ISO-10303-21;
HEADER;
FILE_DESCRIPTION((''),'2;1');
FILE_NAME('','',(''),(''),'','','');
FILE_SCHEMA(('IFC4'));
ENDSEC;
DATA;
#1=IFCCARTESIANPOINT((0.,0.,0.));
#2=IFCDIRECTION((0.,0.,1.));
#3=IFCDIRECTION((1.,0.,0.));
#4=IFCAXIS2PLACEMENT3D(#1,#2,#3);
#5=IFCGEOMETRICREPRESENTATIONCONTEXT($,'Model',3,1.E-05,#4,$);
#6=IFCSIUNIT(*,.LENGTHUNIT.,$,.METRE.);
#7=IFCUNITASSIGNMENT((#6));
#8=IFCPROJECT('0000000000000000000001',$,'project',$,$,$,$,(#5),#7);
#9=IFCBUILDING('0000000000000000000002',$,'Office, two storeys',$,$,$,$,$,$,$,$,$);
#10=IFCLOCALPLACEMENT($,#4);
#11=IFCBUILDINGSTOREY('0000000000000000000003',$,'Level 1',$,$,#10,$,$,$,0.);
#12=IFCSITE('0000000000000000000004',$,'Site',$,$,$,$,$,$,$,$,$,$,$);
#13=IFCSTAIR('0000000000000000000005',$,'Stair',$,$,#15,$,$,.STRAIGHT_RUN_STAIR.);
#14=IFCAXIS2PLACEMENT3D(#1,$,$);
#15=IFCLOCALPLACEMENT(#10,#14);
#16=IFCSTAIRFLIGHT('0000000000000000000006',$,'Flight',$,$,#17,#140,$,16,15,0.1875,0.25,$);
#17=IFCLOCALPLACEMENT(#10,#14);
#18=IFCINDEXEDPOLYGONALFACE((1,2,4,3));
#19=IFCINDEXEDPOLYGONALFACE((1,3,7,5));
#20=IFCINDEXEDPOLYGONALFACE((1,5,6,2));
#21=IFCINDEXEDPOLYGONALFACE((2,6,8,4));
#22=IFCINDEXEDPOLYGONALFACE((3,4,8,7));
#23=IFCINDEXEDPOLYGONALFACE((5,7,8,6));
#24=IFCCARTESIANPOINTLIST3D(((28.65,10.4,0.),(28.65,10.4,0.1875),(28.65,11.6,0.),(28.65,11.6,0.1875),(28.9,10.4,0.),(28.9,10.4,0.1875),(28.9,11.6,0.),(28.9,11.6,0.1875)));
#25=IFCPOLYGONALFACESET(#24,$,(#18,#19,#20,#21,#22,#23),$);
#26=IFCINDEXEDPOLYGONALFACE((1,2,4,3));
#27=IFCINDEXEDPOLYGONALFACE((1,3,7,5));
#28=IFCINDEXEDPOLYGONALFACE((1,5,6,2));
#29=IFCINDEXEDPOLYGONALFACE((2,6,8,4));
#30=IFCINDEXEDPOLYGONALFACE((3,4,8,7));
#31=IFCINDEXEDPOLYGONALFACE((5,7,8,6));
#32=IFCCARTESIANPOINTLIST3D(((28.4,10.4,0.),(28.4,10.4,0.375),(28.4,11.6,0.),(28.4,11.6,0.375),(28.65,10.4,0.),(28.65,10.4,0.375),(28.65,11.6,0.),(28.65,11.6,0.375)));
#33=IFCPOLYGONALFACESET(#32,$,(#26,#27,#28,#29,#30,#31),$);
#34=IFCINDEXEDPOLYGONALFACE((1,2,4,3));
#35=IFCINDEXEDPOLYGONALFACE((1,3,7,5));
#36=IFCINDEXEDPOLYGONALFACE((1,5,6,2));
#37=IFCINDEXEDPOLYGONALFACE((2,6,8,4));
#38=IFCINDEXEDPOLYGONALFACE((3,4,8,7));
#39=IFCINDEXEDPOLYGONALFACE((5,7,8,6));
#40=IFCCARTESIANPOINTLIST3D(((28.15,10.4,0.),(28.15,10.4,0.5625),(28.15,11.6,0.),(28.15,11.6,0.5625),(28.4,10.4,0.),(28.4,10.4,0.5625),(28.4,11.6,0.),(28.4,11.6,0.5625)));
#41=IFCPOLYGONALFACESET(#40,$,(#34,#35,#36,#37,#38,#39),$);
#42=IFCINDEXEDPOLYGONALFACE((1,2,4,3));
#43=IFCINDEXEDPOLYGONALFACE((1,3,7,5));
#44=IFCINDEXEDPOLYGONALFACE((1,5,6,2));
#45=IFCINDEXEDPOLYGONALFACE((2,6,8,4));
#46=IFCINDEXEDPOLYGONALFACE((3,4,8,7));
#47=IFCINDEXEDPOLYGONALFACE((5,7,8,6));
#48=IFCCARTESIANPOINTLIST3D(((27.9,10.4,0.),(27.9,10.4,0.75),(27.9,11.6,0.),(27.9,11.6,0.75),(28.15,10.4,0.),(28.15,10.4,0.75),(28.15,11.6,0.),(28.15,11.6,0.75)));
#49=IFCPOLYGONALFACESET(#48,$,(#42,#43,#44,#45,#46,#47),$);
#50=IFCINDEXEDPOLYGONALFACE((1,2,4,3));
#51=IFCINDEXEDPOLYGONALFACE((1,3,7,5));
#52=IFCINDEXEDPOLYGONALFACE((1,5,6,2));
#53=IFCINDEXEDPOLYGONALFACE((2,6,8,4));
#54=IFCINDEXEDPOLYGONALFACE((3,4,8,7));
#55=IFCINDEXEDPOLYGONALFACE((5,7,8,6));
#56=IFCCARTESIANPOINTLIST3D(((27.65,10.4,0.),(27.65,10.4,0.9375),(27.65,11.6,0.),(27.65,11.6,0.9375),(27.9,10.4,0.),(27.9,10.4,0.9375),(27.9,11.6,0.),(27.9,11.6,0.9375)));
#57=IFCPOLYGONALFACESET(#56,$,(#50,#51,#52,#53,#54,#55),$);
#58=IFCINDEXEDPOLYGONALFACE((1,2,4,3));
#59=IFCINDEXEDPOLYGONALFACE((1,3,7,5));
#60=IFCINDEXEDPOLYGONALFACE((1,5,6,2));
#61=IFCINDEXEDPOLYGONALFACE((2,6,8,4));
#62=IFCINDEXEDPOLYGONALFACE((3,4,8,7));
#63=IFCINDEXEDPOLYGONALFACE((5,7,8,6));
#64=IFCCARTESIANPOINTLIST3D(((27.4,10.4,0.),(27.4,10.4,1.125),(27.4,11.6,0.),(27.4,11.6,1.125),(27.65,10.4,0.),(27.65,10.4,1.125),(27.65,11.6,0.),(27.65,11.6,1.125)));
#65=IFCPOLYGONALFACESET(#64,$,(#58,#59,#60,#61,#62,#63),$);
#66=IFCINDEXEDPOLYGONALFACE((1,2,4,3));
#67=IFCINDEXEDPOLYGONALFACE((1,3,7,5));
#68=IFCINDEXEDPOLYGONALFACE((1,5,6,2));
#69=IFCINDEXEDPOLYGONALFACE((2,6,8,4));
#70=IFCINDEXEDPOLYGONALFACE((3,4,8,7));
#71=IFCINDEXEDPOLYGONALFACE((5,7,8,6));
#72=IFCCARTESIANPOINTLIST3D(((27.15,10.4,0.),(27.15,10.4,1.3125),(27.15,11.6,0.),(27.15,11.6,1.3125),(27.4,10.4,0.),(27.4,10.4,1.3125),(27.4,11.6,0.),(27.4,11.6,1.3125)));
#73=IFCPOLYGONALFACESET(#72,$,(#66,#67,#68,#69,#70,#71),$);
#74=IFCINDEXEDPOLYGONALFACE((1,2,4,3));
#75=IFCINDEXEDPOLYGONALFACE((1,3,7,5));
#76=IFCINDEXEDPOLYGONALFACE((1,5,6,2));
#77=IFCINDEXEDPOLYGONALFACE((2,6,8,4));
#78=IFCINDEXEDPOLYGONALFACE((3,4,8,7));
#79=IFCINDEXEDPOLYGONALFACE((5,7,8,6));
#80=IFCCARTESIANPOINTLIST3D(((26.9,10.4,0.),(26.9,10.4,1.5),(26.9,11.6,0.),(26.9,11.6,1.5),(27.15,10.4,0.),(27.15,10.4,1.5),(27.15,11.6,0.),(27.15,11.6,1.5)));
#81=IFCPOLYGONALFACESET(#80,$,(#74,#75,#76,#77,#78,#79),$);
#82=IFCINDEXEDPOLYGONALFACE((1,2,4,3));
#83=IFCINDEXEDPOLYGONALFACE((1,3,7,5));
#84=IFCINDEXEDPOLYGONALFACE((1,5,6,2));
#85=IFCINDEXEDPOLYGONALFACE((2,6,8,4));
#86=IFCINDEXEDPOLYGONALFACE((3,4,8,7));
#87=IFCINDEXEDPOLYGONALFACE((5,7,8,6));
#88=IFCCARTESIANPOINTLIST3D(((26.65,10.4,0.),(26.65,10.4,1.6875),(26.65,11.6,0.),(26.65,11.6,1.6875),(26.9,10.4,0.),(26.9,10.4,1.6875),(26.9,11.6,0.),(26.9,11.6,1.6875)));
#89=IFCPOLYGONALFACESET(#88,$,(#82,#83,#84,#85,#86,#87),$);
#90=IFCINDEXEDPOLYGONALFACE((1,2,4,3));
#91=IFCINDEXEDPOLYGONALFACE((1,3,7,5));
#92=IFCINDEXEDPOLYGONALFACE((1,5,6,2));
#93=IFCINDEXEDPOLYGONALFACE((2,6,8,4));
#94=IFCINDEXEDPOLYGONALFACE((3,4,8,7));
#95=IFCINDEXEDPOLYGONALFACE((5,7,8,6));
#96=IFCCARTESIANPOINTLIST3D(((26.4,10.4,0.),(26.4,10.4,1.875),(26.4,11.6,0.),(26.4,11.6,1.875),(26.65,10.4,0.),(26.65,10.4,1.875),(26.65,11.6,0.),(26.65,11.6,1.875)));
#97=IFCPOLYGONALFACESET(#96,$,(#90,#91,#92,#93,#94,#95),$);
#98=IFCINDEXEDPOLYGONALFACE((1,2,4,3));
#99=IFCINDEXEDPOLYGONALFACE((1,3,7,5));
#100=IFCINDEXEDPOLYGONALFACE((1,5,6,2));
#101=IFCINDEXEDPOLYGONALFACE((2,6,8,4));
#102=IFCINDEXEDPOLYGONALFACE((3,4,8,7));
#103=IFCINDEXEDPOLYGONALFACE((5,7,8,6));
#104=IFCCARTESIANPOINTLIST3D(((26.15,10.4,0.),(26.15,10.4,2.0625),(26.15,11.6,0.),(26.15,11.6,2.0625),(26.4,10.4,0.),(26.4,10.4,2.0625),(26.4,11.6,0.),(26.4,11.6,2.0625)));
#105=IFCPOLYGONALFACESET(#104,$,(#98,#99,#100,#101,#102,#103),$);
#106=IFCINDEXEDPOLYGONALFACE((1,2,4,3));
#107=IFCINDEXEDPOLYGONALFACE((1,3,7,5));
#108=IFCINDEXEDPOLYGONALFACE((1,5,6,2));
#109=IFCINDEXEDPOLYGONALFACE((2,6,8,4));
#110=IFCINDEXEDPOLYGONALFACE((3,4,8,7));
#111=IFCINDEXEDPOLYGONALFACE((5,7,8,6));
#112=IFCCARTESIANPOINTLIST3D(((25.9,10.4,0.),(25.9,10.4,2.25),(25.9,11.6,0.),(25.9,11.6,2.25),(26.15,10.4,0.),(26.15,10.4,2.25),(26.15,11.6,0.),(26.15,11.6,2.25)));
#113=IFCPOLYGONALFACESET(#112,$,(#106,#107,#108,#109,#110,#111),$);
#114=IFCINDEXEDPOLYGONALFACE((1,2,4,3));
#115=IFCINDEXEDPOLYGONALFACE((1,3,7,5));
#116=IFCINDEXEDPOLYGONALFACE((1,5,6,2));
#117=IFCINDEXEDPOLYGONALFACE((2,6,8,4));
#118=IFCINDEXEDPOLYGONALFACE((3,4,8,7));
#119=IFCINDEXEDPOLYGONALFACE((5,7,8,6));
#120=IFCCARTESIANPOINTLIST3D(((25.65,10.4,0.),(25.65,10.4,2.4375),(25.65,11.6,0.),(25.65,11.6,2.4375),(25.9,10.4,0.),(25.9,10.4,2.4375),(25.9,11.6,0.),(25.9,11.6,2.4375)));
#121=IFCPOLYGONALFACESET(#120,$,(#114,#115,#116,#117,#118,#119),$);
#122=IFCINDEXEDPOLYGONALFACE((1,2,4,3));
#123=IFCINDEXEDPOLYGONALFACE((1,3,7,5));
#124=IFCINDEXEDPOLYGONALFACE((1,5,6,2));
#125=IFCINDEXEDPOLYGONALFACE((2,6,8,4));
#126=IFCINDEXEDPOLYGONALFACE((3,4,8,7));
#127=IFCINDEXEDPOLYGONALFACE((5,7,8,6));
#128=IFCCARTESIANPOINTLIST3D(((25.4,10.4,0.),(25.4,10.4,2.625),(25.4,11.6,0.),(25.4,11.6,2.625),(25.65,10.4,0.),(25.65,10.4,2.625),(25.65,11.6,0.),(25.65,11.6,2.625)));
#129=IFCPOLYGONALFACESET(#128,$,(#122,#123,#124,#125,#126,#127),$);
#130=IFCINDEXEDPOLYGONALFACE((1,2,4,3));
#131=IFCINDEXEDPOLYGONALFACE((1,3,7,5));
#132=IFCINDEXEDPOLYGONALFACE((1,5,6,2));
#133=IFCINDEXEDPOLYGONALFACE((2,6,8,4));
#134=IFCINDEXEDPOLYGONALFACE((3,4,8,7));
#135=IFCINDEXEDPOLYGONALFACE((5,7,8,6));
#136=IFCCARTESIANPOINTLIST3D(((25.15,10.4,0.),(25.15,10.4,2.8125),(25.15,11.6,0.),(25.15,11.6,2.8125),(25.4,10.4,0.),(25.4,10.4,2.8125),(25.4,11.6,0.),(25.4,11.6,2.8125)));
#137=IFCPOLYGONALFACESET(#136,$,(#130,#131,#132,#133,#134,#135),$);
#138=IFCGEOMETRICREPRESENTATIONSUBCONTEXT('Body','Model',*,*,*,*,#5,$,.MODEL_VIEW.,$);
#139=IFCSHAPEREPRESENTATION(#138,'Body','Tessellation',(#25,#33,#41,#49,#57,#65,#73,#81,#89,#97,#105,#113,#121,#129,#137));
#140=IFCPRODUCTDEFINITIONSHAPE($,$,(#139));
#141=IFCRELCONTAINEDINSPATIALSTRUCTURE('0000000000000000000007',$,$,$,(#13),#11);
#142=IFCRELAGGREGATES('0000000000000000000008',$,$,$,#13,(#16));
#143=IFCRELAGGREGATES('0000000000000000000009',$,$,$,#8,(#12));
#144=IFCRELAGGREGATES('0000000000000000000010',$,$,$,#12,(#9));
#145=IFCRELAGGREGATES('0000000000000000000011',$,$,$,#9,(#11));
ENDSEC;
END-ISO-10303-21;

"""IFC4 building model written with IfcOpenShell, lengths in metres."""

from ifc_helpers import new_model, si_unit, frame, origin_with_axes, place, context, subcontext, project, spatial, line, indexed_curve, outline, extrude, element, aggregate, save


model = new_model("IFC4")

# Units and contexts
model_context = context("Model", 3, precision=1e-05, world=origin_with_axes())
body_context = subcontext(model_context, "Body", "Model", "MODEL_VIEW")
ifc_project = project(units=[si_unit("LENGTHUNIT", "METRE")], contexts=[model_context])

# Site, building, storey
site = spatial("IfcSite", under=ifc_project, Name="Site")
building = spatial("IfcBuilding", under=site, Name="Office, two storeys")
storey_placement = place(None, origin_with_axes())
storey = spatial("IfcBuildingStorey", under=building, at=storey_placement, Name="Level 1", Elevation=0.0)

# Stair, stair flight
stair_placement = place(storey_placement, frame((28.9, 11.0, 0.0), z_axis=(0.0, 0.0, 1.0), x_axis=(-1.0, 0.0, 0.0)))
stair = element("IfcStair", 1, at=stair_placement, inside=storey, Name="Stair", PredefinedType="STRAIGHT_RUN_STAIR")
stair_flight_placement = place(stair_placement, origin_with_axes())
stair_flight = element("IfcStairFlight", 2, at=stair_flight_placement, Name="Flight", NumberOfRisers=16, NumberOfTreads=15, RiserHeight=0.1875, TreadLength=0.25, context=body_context, shape_type="SweptSolid", body=[
    extrude(outline(indexed_curve([(0.0, 0.0), (0.25, 0.0), (0.25, 1.2), (0.0, 1.2)], segments=[line(1, 2, 3, 4, 1)])), frame((0.0, -0.6, 0.0), z_axis=(0.0, 0.0, 1.0), x_axis=(1.0, 0.0, 0.0)), (0.0, 0.0, 1.0), 0.1875),
    extrude(outline(indexed_curve([(0.0, 0.0), (0.25, 0.0), (0.25, 1.2), (0.0, 1.2)], segments=[line(1, 2, 3, 4, 1)])), frame((0.25, -0.6, 0.0), z_axis=(0.0, 0.0, 1.0), x_axis=(1.0, 0.0, 0.0)), (0.0, 0.0, 1.0), 0.375),
    extrude(outline(indexed_curve([(0.0, 0.0), (0.25, 0.0), (0.25, 1.2), (0.0, 1.2)], segments=[line(1, 2, 3, 4, 1)])), frame((0.5, -0.6, 0.0), z_axis=(0.0, 0.0, 1.0), x_axis=(1.0, 0.0, 0.0)), (0.0, 0.0, 1.0), 0.5625),
    extrude(outline(indexed_curve([(0.0, 0.0), (0.25, 0.0), (0.25, 1.2), (0.0, 1.2)], segments=[line(1, 2, 3, 4, 1)])), frame((0.75, -0.6, 0.0), z_axis=(0.0, 0.0, 1.0), x_axis=(1.0, 0.0, 0.0)), (0.0, 0.0, 1.0), 0.75),
    extrude(outline(indexed_curve([(0.0, 0.0), (0.25, 0.0), (0.25, 1.2), (0.0, 1.2)], segments=[line(1, 2, 3, 4, 1)])), frame((1.0, -0.6, 0.0), z_axis=(0.0, 0.0, 1.0), x_axis=(1.0, 0.0, 0.0)), (0.0, 0.0, 1.0), 0.9375),
    extrude(outline(indexed_curve([(0.0, 0.0), (0.25, 0.0), (0.25, 1.2), (0.0, 1.2)], segments=[line(1, 2, 3, 4, 1)])), frame((1.25, -0.6, 0.0), z_axis=(0.0, 0.0, 1.0), x_axis=(1.0, 0.0, 0.0)), (0.0, 0.0, 1.0), 1.125),
    extrude(outline(indexed_curve([(0.0, 0.0), (0.25, 0.0), (0.25, 1.2), (0.0, 1.2)], segments=[line(1, 2, 3, 4, 1)])), frame((1.5, -0.6, 0.0), z_axis=(0.0, 0.0, 1.0), x_axis=(1.0, 0.0, 0.0)), (0.0, 0.0, 1.0), 1.3125),
    extrude(outline(indexed_curve([(0.0, 0.0), (0.25, 0.0), (0.25, 1.2), (0.0, 1.2)], segments=[line(1, 2, 3, 4, 1)])), frame((1.75, -0.6, 0.0), z_axis=(0.0, 0.0, 1.0), x_axis=(1.0, 0.0, 0.0)), (0.0, 0.0, 1.0), 1.5),
    extrude(outline(indexed_curve([(0.0, 0.0), (0.25, 0.0), (0.25, 1.2), (0.0, 1.2)], segments=[line(1, 2, 3, 4, 1)])), frame((2.0, -0.6, 0.0), z_axis=(0.0, 0.0, 1.0), x_axis=(1.0, 0.0, 0.0)), (0.0, 0.0, 1.0), 1.6875),
    extrude(outline(indexed_curve([(0.0, 0.0), (0.25, 0.0), (0.25, 1.2), (0.0, 1.2)], segments=[line(1, 2, 3, 4, 1)])), frame((2.25, -0.6, 0.0), z_axis=(0.0, 0.0, 1.0), x_axis=(1.0, 0.0, 0.0)), (0.0, 0.0, 1.0), 1.875),
    extrude(outline(indexed_curve([(0.0, 0.0), (0.25, 0.0), (0.25, 1.2), (0.0, 1.2)], segments=[line(1, 2, 3, 4, 1)])), frame((2.5, -0.6, 0.0), z_axis=(0.0, 0.0, 1.0), x_axis=(1.0, 0.0, 0.0)), (0.0, 0.0, 1.0), 2.0625),
    extrude(outline(indexed_curve([(0.0, 0.0), (0.25, 0.0), (0.25, 1.2), (0.0, 1.2)], segments=[line(1, 2, 3, 4, 1)])), frame((2.75, -0.6, 0.0), z_axis=(0.0, 0.0, 1.0), x_axis=(1.0, 0.0, 0.0)), (0.0, 0.0, 1.0), 2.25),
    extrude(outline(indexed_curve([(0.0, 0.0), (0.25, 0.0), (0.25, 1.2), (0.0, 1.2)], segments=[line(1, 2, 3, 4, 1)])), frame((3.0, -0.6, 0.0), z_axis=(0.0, 0.0, 1.0), x_axis=(1.0, 0.0, 0.0)), (0.0, 0.0, 1.0), 2.4375),
    extrude(outline(indexed_curve([(0.0, 0.0), (0.25, 0.0), (0.25, 1.2), (0.0, 1.2)], segments=[line(1, 2, 3, 4, 1)])), frame((3.25, -0.6, 0.0), z_axis=(0.0, 0.0, 1.0), x_axis=(1.0, 0.0, 0.0)), (0.0, 0.0, 1.0), 2.625),
    extrude(outline(indexed_curve([(0.0, 0.0), (0.25, 0.0), (0.25, 1.2), (0.0, 1.2)], segments=[line(1, 2, 3, 4, 1)])), frame((3.5, -0.6, 0.0), z_axis=(0.0, 0.0, 1.0), x_axis=(1.0, 0.0, 0.0)), (0.0, 0.0, 1.0), 2.8125),
])
aggregate(stair, [stair_flight])

save(model, "model.ifc")
